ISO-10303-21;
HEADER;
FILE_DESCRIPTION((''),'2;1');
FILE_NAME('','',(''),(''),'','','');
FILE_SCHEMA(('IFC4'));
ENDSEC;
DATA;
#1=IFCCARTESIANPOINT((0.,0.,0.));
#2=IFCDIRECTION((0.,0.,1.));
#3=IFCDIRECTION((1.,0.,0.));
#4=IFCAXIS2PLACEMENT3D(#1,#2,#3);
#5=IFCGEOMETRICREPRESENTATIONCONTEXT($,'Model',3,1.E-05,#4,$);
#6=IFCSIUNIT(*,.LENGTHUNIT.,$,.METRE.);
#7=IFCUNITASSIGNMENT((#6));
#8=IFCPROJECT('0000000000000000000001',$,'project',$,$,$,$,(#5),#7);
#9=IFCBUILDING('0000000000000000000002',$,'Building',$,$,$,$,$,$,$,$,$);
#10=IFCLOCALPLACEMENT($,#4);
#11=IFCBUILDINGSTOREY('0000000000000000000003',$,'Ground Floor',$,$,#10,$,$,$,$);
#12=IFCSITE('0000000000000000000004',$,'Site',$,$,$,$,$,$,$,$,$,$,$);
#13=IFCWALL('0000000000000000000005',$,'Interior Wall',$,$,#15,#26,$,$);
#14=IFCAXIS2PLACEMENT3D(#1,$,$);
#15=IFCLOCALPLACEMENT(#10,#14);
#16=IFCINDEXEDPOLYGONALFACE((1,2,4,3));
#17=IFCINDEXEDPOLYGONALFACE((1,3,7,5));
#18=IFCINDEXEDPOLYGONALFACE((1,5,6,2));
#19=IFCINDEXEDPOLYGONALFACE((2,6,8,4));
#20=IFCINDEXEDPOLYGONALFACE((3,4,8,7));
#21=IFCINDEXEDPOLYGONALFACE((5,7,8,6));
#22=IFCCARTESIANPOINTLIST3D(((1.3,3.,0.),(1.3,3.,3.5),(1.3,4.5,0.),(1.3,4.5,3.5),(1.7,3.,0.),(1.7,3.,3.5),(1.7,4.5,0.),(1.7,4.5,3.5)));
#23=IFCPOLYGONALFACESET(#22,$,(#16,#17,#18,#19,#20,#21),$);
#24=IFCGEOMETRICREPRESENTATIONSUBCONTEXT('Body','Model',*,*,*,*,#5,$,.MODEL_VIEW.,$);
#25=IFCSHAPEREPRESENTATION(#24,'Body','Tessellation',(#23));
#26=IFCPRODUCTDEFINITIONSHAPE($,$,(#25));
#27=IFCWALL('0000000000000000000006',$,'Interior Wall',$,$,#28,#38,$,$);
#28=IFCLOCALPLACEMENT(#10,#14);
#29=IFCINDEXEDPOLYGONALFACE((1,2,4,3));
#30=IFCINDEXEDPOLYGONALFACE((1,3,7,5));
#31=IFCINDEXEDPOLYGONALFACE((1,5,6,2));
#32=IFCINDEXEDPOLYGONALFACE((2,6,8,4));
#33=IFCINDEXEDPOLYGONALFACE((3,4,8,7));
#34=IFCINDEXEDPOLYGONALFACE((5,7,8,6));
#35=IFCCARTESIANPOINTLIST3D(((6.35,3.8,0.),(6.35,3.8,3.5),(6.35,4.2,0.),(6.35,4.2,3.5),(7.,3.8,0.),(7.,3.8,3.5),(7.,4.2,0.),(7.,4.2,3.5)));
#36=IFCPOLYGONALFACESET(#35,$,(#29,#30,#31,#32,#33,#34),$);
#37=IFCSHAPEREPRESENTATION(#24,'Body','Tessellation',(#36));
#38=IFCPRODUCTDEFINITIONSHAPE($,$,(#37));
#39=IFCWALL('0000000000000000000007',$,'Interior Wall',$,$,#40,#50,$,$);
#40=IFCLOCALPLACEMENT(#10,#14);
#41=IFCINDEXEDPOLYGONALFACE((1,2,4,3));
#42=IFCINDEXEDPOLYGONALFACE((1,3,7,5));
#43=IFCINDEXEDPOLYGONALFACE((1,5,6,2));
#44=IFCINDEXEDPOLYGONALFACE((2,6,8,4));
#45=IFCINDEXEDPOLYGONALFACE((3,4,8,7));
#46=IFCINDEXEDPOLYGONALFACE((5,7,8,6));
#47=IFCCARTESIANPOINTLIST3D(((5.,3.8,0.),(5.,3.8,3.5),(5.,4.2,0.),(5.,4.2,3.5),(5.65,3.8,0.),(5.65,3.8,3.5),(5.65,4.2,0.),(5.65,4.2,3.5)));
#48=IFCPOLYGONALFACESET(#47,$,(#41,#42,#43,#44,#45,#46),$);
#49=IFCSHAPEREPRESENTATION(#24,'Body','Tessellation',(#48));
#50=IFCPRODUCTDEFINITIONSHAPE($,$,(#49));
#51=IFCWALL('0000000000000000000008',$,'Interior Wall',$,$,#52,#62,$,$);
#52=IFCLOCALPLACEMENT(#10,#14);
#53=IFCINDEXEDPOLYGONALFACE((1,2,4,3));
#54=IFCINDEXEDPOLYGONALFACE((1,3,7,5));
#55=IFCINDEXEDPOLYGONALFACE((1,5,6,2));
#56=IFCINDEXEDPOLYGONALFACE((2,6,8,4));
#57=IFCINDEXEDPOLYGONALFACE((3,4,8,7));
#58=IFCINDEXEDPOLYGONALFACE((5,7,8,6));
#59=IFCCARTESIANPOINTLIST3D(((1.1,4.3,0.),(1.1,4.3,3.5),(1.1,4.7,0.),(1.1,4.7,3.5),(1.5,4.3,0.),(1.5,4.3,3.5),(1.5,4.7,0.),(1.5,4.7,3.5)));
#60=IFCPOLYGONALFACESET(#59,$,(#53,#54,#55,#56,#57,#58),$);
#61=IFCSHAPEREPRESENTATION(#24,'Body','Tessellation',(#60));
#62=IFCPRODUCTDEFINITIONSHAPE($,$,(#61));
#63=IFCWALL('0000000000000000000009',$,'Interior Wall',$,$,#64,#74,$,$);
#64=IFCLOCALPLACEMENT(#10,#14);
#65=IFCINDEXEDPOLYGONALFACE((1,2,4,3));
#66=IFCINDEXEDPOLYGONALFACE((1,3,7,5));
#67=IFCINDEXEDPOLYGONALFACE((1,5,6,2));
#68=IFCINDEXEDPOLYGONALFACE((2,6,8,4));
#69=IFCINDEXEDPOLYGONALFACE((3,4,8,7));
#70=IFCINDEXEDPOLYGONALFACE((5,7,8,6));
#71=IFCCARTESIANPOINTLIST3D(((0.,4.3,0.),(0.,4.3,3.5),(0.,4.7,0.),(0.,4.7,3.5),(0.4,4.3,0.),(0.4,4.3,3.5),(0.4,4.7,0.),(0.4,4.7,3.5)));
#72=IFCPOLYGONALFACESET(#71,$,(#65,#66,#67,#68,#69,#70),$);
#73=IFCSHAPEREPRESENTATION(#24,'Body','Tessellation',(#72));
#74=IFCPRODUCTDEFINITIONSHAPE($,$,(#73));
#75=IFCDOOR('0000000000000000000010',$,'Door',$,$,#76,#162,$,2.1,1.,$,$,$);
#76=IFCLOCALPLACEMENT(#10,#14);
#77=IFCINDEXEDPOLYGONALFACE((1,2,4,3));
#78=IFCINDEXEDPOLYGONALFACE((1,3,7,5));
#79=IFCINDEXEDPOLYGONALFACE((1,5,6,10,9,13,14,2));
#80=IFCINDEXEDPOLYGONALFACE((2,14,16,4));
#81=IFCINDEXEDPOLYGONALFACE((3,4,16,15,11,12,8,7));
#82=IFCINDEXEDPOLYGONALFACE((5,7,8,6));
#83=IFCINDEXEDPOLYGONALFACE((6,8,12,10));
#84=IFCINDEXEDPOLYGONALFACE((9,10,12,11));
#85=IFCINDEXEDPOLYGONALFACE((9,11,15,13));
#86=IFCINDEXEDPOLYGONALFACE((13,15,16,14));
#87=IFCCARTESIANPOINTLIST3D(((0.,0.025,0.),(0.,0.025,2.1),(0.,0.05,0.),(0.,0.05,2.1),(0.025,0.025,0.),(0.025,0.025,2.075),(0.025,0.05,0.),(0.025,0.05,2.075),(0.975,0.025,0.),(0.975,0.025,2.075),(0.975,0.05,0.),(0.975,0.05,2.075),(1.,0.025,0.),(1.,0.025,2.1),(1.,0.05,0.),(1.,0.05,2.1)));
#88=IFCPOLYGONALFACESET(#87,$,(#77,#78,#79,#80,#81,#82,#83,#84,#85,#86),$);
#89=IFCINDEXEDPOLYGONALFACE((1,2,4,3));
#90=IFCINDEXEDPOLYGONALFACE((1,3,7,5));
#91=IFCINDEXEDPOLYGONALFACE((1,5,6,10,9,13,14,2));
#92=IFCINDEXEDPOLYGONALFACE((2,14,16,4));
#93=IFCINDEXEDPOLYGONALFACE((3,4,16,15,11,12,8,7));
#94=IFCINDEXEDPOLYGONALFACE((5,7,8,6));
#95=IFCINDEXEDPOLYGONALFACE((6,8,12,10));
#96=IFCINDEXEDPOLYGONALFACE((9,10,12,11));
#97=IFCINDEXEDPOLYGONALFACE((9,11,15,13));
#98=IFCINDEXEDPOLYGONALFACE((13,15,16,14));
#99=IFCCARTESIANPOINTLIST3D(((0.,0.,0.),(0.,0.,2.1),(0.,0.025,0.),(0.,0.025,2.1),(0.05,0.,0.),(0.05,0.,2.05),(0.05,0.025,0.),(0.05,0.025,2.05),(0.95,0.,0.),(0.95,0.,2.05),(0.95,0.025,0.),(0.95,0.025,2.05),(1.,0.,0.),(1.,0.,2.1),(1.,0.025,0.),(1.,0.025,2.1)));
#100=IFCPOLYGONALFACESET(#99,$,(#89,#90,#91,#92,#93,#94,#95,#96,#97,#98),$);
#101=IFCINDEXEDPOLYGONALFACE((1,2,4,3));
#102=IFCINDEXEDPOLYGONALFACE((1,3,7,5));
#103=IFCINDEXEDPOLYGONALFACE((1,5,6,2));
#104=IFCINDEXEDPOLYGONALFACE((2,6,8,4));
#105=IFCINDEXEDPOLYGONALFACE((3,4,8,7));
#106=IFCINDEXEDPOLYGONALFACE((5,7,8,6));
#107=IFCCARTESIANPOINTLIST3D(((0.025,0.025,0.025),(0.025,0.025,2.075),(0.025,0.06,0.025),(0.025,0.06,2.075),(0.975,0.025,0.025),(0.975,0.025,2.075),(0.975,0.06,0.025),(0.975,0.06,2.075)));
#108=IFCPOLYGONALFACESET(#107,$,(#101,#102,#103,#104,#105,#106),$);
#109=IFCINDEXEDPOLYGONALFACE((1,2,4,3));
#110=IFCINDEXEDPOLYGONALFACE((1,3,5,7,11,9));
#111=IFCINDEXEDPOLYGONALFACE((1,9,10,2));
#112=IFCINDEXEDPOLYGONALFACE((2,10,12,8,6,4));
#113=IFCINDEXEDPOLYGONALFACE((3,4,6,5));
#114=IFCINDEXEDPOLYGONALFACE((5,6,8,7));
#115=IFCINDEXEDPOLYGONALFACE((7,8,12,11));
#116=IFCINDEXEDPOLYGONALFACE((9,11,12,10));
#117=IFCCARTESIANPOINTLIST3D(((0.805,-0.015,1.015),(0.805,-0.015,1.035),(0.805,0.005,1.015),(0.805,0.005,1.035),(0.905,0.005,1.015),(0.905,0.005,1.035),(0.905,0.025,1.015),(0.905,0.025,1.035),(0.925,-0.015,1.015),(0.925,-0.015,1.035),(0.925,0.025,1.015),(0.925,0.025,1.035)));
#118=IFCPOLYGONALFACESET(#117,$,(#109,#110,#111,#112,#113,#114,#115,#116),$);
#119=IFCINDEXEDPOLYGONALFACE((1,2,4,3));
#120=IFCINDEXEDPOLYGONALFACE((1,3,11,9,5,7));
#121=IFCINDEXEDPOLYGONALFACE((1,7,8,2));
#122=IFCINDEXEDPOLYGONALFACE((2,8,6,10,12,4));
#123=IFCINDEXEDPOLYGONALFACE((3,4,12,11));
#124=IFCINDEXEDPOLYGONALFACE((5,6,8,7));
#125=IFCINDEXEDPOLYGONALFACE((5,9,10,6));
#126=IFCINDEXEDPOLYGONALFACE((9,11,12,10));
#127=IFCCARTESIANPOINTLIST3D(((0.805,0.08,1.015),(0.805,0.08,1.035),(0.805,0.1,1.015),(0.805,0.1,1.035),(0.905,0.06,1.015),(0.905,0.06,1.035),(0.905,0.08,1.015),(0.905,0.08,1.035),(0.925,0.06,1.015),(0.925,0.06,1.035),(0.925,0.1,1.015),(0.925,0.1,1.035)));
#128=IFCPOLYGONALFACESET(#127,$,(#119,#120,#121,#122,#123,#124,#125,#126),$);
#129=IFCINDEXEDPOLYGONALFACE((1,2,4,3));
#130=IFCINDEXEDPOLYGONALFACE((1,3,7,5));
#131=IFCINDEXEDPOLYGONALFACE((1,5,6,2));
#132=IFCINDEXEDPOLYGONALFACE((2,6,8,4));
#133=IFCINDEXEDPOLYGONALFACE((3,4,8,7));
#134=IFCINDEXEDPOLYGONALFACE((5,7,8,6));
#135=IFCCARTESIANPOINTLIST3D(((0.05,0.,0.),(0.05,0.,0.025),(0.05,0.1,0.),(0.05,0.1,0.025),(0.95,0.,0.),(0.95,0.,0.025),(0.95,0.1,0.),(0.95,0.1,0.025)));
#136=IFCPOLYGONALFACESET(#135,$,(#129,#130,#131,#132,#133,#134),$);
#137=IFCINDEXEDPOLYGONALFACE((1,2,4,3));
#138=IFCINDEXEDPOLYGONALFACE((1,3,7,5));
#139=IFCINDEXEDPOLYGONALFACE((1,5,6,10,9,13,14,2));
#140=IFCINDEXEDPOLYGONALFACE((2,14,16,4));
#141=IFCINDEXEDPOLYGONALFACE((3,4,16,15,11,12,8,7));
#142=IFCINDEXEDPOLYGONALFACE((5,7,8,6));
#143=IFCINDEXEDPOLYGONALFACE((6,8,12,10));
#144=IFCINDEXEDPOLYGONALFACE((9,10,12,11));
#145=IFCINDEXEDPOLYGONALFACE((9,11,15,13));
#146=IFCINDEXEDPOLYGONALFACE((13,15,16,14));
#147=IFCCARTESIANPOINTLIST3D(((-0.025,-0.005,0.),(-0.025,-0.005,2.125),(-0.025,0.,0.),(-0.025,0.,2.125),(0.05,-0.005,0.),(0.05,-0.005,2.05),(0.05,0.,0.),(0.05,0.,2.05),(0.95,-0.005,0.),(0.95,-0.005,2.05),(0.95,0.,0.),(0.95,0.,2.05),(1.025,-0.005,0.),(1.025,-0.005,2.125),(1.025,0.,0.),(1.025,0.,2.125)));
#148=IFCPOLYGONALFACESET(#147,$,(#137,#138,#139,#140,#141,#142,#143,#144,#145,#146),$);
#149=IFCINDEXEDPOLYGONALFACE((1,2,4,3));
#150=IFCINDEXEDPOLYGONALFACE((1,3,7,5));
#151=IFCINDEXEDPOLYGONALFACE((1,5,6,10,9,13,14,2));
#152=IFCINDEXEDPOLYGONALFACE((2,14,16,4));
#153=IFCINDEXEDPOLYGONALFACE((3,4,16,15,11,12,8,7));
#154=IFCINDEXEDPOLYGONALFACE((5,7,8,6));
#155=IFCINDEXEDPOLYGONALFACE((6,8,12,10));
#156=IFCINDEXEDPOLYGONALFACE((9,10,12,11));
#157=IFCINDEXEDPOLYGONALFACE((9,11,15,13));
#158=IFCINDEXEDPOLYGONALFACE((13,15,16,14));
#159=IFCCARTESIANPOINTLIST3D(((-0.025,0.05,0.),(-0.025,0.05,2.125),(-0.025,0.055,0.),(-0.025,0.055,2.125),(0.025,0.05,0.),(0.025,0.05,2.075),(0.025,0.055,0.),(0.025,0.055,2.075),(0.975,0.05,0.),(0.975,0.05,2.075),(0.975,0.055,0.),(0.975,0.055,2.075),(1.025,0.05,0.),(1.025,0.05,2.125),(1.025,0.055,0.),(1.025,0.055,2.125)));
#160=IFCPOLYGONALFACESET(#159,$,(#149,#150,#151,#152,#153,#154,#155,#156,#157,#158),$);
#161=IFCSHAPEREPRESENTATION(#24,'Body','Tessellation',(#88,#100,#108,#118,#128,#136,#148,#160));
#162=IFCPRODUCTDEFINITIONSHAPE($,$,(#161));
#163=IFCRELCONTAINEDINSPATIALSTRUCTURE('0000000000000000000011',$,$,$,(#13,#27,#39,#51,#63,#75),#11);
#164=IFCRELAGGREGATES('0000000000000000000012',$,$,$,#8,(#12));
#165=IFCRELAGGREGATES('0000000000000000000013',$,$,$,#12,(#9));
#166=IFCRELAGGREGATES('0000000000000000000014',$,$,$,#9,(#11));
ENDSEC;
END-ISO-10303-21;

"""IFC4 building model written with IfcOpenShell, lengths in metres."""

from ifc_helpers import new_model, si_unit, frame, origin_with_axes, place, context, subcontext, project, spatial, line, indexed_curve, outline, extrude, element, save


model = new_model("IFC4")

# Units and contexts
model_context = context("Model", 3, precision=1e-05, world=origin_with_axes())
body_context = subcontext(model_context, "Body", "Model", "MODEL_VIEW")
ifc_project = project(units=[si_unit("LENGTHUNIT", "METRE")], contexts=[model_context])

# Site, building, storey
site = spatial("IfcSite", under=ifc_project, Name="Site")
building = spatial("IfcBuilding", under=site, Name="Building")
storey_placement = place(None, origin_with_axes())
storey = spatial("IfcBuildingStorey", under=building, at=storey_placement, Name="Ground Floor")

# Walls
wall_1_placement = place(storey_placement, frame((1.5, 4.5, 0.0), z_axis=(0.0, 0.0, 1.0), x_axis=(0.0, -1.0, 0.0)))
element("IfcWall", 1, at=wall_1_placement, inside=storey, Name="Interior Wall", context=body_context, shape_type="SweptSolid", body=[
    extrude(outline(indexed_curve([(0.0, 0.0), (0.0, 0.4), (1.5, 0.4), (1.5, 0.0), (0.0, 0.0)], self_intersect=False)), frame((0.0, -0.2, 0.0), z_axis=(0.0, 0.0, 1.0), x_axis=(1.0, 0.0, 0.0)), (0.0, 0.0, 1.0), 3.5),
])
for number, where, z_axis, x_axis, name in (
    (2, (7.0, 4.0, 0.0), (0.0, 0.0, 1.0), (-1.0, 0.0, 0.0), "Interior Wall"),
    (3, (5.65, 4.0, 0.0), (0.0, 0.0, 1.0), (-1.0, 0.0, 0.0), "Interior Wall"),
):
    element("IfcWall", number, at=place(storey_placement, frame(where, z_axis=z_axis, x_axis=x_axis)), inside=storey, Name=name, context=body_context, shape_type="SweptSolid", body=[
        extrude(outline(indexed_curve([(0.0, 0.0), (0.0, 0.4), (0.65, 0.4), (0.65, 0.0), (0.0, 0.0)], self_intersect=False)), frame((0.0, -0.2, 0.0), z_axis=(0.0, 0.0, 1.0), x_axis=(1.0, 0.0, 0.0)), (0.0, 0.0, 1.0), 3.5),
    ])
for number, where, z_axis, x_axis, name in (
    (4, (1.5, 4.5, 0.0), (0.0, 0.0, 1.0), (-1.0, 0.0, 0.0), "Interior Wall"),
    (5, (0.4, 4.5, 0.0), (0.0, 0.0, 1.0), (-1.0, 0.0, 0.0), "Interior Wall"),
):
    element("IfcWall", number, at=place(storey_placement, frame(where, z_axis=z_axis, x_axis=x_axis)), inside=storey, Name=name, context=body_context, shape_type="SweptSolid", body=[
        extrude(outline(indexed_curve([(0.0, 0.0), (0.0, 0.4), (0.4, 0.4), (0.4, 0.0), (0.0, 0.0)], self_intersect=False)), frame((0.0, -0.2, 0.0), z_axis=(0.0, 0.0, 1.0), x_axis=(1.0, 0.0, 0.0)), (0.0, 0.0, 1.0), 3.5),
    ])

# Door
door_1_placement = place(storey_placement, origin_with_axes())
element("IfcDoor", 6, at=door_1_placement, inside=storey, Name="Door", OverallHeight=2.1, OverallWidth=1.0, context=body_context, shape_type="SweptSolid", body=[
    extrude(outline(indexed_curve([(0.0, 0.0), (0.0, 2.1), (1.0, 2.1), (1.0, 0.0), (0.975, 0.0), (0.975, 2.075), (0.025, 2.075), (0.025, 0.0)], segments=[line(1, 2, 3, 4, 5, 6, 7, 8, 1)])), frame((0.0, 0.025, 0.0), z_axis=(0.0, -1.0, 0.0), x_axis=(1.0, 0.0, 0.0)), (0.0, 0.0, -1.0), 0.025),
    extrude(outline(indexed_curve([(0.0, 0.0), (0.0, 2.1), (1.0, 2.1), (1.0, 0.0), (0.95, 0.0), (0.95, 2.05), (0.05, 2.05), (0.05, 0.0)], segments=[line(1, 2, 3, 4, 5, 6, 7, 8, 1)])), frame((0.0, 0.0, 0.0), z_axis=(0.0, -1.0, 0.0), x_axis=(1.0, 0.0, 0.0)), (0.0, 0.0, -1.0), 0.025),
    extrude(outline(indexed_curve([(0.0, 0.0), (0.95, 0.0), (0.95, 0.035), (0.0, 0.035)], segments=[line(1, 2, 3, 4, 1)])), frame((0.025, 0.025, 0.025), z_axis=(0.0, 0.0, 1.0), x_axis=(1.0, 0.0, 0.0)), (0.0, 0.0, 1.0), 2.05),
    extrude(outline(indexed_curve([(0.0, 0.0), (0.0, -0.04), (-0.12, -0.04), (-0.12, -0.02), (-0.02, -0.02), (-0.02, 0.0)], segments=[line(1, 2, 3, 4, 5, 6, 1)])), frame((0.925, 0.025, 1.015), z_axis=(0.0, 0.0, 1.0), x_axis=(1.0, 0.0, 0.0)), (0.0, 0.0, 1.0), 0.02),
    extrude(outline(indexed_curve([(0.0, 0.0), (0.0, 0.04), (-0.12, 0.04), (-0.12, 0.02), (-0.02, 0.02), (-0.02, 0.0)], segments=[line(1, 2, 3, 4, 5, 6, 1)])), frame((0.925, 0.06, 1.015), z_axis=(0.0, 0.0, 1.0), x_axis=(1.0, 0.0, 0.0)), (0.0, 0.0, 1.0), 0.02),
    extrude(outline(indexed_curve([(0.0, 0.0), (0.9, 0.0), (0.9, 0.1), (0.0, 0.1)], segments=[line(1, 2, 3, 4, 1)])), frame((0.05, 0.0, 0.0), z_axis=(0.0, 0.0, 1.0), x_axis=(1.0, 0.0, 0.0)), (0.0, 0.0, 1.0), 0.025),
    extrude(outline(indexed_curve([(0.0, 0.0), (0.0, 2.125), (1.05, 2.125), (1.05, 0.0), (0.975, 0.0), (0.975, 2.05), (0.075, 2.05), (0.075, 0.0)], segments=[line(1, 2, 3, 4, 5, 6, 7, 8, 1)])), frame((-0.025, -0.005, 0.0), z_axis=(0.0, -1.0, 0.0), x_axis=(1.0, 0.0, 0.0)), (0.0, 0.0, -1.0), 0.005),
    extrude(outline(indexed_curve([(0.0, 0.0), (0.0, 2.125), (1.05, 2.125), (1.05, 0.0), (1.0, 0.0), (1.0, 2.075), (0.05, 2.075), (0.05, 0.0)], segments=[line(1, 2, 3, 4, 5, 6, 7, 8, 1)])), frame((-0.025, 0.05, 0.0), z_axis=(0.0, -1.0, 0.0), x_axis=(1.0, 0.0, 0.0)), (0.0, 0.0, -1.0), 0.005),
])

save(model, "model.ifc")
